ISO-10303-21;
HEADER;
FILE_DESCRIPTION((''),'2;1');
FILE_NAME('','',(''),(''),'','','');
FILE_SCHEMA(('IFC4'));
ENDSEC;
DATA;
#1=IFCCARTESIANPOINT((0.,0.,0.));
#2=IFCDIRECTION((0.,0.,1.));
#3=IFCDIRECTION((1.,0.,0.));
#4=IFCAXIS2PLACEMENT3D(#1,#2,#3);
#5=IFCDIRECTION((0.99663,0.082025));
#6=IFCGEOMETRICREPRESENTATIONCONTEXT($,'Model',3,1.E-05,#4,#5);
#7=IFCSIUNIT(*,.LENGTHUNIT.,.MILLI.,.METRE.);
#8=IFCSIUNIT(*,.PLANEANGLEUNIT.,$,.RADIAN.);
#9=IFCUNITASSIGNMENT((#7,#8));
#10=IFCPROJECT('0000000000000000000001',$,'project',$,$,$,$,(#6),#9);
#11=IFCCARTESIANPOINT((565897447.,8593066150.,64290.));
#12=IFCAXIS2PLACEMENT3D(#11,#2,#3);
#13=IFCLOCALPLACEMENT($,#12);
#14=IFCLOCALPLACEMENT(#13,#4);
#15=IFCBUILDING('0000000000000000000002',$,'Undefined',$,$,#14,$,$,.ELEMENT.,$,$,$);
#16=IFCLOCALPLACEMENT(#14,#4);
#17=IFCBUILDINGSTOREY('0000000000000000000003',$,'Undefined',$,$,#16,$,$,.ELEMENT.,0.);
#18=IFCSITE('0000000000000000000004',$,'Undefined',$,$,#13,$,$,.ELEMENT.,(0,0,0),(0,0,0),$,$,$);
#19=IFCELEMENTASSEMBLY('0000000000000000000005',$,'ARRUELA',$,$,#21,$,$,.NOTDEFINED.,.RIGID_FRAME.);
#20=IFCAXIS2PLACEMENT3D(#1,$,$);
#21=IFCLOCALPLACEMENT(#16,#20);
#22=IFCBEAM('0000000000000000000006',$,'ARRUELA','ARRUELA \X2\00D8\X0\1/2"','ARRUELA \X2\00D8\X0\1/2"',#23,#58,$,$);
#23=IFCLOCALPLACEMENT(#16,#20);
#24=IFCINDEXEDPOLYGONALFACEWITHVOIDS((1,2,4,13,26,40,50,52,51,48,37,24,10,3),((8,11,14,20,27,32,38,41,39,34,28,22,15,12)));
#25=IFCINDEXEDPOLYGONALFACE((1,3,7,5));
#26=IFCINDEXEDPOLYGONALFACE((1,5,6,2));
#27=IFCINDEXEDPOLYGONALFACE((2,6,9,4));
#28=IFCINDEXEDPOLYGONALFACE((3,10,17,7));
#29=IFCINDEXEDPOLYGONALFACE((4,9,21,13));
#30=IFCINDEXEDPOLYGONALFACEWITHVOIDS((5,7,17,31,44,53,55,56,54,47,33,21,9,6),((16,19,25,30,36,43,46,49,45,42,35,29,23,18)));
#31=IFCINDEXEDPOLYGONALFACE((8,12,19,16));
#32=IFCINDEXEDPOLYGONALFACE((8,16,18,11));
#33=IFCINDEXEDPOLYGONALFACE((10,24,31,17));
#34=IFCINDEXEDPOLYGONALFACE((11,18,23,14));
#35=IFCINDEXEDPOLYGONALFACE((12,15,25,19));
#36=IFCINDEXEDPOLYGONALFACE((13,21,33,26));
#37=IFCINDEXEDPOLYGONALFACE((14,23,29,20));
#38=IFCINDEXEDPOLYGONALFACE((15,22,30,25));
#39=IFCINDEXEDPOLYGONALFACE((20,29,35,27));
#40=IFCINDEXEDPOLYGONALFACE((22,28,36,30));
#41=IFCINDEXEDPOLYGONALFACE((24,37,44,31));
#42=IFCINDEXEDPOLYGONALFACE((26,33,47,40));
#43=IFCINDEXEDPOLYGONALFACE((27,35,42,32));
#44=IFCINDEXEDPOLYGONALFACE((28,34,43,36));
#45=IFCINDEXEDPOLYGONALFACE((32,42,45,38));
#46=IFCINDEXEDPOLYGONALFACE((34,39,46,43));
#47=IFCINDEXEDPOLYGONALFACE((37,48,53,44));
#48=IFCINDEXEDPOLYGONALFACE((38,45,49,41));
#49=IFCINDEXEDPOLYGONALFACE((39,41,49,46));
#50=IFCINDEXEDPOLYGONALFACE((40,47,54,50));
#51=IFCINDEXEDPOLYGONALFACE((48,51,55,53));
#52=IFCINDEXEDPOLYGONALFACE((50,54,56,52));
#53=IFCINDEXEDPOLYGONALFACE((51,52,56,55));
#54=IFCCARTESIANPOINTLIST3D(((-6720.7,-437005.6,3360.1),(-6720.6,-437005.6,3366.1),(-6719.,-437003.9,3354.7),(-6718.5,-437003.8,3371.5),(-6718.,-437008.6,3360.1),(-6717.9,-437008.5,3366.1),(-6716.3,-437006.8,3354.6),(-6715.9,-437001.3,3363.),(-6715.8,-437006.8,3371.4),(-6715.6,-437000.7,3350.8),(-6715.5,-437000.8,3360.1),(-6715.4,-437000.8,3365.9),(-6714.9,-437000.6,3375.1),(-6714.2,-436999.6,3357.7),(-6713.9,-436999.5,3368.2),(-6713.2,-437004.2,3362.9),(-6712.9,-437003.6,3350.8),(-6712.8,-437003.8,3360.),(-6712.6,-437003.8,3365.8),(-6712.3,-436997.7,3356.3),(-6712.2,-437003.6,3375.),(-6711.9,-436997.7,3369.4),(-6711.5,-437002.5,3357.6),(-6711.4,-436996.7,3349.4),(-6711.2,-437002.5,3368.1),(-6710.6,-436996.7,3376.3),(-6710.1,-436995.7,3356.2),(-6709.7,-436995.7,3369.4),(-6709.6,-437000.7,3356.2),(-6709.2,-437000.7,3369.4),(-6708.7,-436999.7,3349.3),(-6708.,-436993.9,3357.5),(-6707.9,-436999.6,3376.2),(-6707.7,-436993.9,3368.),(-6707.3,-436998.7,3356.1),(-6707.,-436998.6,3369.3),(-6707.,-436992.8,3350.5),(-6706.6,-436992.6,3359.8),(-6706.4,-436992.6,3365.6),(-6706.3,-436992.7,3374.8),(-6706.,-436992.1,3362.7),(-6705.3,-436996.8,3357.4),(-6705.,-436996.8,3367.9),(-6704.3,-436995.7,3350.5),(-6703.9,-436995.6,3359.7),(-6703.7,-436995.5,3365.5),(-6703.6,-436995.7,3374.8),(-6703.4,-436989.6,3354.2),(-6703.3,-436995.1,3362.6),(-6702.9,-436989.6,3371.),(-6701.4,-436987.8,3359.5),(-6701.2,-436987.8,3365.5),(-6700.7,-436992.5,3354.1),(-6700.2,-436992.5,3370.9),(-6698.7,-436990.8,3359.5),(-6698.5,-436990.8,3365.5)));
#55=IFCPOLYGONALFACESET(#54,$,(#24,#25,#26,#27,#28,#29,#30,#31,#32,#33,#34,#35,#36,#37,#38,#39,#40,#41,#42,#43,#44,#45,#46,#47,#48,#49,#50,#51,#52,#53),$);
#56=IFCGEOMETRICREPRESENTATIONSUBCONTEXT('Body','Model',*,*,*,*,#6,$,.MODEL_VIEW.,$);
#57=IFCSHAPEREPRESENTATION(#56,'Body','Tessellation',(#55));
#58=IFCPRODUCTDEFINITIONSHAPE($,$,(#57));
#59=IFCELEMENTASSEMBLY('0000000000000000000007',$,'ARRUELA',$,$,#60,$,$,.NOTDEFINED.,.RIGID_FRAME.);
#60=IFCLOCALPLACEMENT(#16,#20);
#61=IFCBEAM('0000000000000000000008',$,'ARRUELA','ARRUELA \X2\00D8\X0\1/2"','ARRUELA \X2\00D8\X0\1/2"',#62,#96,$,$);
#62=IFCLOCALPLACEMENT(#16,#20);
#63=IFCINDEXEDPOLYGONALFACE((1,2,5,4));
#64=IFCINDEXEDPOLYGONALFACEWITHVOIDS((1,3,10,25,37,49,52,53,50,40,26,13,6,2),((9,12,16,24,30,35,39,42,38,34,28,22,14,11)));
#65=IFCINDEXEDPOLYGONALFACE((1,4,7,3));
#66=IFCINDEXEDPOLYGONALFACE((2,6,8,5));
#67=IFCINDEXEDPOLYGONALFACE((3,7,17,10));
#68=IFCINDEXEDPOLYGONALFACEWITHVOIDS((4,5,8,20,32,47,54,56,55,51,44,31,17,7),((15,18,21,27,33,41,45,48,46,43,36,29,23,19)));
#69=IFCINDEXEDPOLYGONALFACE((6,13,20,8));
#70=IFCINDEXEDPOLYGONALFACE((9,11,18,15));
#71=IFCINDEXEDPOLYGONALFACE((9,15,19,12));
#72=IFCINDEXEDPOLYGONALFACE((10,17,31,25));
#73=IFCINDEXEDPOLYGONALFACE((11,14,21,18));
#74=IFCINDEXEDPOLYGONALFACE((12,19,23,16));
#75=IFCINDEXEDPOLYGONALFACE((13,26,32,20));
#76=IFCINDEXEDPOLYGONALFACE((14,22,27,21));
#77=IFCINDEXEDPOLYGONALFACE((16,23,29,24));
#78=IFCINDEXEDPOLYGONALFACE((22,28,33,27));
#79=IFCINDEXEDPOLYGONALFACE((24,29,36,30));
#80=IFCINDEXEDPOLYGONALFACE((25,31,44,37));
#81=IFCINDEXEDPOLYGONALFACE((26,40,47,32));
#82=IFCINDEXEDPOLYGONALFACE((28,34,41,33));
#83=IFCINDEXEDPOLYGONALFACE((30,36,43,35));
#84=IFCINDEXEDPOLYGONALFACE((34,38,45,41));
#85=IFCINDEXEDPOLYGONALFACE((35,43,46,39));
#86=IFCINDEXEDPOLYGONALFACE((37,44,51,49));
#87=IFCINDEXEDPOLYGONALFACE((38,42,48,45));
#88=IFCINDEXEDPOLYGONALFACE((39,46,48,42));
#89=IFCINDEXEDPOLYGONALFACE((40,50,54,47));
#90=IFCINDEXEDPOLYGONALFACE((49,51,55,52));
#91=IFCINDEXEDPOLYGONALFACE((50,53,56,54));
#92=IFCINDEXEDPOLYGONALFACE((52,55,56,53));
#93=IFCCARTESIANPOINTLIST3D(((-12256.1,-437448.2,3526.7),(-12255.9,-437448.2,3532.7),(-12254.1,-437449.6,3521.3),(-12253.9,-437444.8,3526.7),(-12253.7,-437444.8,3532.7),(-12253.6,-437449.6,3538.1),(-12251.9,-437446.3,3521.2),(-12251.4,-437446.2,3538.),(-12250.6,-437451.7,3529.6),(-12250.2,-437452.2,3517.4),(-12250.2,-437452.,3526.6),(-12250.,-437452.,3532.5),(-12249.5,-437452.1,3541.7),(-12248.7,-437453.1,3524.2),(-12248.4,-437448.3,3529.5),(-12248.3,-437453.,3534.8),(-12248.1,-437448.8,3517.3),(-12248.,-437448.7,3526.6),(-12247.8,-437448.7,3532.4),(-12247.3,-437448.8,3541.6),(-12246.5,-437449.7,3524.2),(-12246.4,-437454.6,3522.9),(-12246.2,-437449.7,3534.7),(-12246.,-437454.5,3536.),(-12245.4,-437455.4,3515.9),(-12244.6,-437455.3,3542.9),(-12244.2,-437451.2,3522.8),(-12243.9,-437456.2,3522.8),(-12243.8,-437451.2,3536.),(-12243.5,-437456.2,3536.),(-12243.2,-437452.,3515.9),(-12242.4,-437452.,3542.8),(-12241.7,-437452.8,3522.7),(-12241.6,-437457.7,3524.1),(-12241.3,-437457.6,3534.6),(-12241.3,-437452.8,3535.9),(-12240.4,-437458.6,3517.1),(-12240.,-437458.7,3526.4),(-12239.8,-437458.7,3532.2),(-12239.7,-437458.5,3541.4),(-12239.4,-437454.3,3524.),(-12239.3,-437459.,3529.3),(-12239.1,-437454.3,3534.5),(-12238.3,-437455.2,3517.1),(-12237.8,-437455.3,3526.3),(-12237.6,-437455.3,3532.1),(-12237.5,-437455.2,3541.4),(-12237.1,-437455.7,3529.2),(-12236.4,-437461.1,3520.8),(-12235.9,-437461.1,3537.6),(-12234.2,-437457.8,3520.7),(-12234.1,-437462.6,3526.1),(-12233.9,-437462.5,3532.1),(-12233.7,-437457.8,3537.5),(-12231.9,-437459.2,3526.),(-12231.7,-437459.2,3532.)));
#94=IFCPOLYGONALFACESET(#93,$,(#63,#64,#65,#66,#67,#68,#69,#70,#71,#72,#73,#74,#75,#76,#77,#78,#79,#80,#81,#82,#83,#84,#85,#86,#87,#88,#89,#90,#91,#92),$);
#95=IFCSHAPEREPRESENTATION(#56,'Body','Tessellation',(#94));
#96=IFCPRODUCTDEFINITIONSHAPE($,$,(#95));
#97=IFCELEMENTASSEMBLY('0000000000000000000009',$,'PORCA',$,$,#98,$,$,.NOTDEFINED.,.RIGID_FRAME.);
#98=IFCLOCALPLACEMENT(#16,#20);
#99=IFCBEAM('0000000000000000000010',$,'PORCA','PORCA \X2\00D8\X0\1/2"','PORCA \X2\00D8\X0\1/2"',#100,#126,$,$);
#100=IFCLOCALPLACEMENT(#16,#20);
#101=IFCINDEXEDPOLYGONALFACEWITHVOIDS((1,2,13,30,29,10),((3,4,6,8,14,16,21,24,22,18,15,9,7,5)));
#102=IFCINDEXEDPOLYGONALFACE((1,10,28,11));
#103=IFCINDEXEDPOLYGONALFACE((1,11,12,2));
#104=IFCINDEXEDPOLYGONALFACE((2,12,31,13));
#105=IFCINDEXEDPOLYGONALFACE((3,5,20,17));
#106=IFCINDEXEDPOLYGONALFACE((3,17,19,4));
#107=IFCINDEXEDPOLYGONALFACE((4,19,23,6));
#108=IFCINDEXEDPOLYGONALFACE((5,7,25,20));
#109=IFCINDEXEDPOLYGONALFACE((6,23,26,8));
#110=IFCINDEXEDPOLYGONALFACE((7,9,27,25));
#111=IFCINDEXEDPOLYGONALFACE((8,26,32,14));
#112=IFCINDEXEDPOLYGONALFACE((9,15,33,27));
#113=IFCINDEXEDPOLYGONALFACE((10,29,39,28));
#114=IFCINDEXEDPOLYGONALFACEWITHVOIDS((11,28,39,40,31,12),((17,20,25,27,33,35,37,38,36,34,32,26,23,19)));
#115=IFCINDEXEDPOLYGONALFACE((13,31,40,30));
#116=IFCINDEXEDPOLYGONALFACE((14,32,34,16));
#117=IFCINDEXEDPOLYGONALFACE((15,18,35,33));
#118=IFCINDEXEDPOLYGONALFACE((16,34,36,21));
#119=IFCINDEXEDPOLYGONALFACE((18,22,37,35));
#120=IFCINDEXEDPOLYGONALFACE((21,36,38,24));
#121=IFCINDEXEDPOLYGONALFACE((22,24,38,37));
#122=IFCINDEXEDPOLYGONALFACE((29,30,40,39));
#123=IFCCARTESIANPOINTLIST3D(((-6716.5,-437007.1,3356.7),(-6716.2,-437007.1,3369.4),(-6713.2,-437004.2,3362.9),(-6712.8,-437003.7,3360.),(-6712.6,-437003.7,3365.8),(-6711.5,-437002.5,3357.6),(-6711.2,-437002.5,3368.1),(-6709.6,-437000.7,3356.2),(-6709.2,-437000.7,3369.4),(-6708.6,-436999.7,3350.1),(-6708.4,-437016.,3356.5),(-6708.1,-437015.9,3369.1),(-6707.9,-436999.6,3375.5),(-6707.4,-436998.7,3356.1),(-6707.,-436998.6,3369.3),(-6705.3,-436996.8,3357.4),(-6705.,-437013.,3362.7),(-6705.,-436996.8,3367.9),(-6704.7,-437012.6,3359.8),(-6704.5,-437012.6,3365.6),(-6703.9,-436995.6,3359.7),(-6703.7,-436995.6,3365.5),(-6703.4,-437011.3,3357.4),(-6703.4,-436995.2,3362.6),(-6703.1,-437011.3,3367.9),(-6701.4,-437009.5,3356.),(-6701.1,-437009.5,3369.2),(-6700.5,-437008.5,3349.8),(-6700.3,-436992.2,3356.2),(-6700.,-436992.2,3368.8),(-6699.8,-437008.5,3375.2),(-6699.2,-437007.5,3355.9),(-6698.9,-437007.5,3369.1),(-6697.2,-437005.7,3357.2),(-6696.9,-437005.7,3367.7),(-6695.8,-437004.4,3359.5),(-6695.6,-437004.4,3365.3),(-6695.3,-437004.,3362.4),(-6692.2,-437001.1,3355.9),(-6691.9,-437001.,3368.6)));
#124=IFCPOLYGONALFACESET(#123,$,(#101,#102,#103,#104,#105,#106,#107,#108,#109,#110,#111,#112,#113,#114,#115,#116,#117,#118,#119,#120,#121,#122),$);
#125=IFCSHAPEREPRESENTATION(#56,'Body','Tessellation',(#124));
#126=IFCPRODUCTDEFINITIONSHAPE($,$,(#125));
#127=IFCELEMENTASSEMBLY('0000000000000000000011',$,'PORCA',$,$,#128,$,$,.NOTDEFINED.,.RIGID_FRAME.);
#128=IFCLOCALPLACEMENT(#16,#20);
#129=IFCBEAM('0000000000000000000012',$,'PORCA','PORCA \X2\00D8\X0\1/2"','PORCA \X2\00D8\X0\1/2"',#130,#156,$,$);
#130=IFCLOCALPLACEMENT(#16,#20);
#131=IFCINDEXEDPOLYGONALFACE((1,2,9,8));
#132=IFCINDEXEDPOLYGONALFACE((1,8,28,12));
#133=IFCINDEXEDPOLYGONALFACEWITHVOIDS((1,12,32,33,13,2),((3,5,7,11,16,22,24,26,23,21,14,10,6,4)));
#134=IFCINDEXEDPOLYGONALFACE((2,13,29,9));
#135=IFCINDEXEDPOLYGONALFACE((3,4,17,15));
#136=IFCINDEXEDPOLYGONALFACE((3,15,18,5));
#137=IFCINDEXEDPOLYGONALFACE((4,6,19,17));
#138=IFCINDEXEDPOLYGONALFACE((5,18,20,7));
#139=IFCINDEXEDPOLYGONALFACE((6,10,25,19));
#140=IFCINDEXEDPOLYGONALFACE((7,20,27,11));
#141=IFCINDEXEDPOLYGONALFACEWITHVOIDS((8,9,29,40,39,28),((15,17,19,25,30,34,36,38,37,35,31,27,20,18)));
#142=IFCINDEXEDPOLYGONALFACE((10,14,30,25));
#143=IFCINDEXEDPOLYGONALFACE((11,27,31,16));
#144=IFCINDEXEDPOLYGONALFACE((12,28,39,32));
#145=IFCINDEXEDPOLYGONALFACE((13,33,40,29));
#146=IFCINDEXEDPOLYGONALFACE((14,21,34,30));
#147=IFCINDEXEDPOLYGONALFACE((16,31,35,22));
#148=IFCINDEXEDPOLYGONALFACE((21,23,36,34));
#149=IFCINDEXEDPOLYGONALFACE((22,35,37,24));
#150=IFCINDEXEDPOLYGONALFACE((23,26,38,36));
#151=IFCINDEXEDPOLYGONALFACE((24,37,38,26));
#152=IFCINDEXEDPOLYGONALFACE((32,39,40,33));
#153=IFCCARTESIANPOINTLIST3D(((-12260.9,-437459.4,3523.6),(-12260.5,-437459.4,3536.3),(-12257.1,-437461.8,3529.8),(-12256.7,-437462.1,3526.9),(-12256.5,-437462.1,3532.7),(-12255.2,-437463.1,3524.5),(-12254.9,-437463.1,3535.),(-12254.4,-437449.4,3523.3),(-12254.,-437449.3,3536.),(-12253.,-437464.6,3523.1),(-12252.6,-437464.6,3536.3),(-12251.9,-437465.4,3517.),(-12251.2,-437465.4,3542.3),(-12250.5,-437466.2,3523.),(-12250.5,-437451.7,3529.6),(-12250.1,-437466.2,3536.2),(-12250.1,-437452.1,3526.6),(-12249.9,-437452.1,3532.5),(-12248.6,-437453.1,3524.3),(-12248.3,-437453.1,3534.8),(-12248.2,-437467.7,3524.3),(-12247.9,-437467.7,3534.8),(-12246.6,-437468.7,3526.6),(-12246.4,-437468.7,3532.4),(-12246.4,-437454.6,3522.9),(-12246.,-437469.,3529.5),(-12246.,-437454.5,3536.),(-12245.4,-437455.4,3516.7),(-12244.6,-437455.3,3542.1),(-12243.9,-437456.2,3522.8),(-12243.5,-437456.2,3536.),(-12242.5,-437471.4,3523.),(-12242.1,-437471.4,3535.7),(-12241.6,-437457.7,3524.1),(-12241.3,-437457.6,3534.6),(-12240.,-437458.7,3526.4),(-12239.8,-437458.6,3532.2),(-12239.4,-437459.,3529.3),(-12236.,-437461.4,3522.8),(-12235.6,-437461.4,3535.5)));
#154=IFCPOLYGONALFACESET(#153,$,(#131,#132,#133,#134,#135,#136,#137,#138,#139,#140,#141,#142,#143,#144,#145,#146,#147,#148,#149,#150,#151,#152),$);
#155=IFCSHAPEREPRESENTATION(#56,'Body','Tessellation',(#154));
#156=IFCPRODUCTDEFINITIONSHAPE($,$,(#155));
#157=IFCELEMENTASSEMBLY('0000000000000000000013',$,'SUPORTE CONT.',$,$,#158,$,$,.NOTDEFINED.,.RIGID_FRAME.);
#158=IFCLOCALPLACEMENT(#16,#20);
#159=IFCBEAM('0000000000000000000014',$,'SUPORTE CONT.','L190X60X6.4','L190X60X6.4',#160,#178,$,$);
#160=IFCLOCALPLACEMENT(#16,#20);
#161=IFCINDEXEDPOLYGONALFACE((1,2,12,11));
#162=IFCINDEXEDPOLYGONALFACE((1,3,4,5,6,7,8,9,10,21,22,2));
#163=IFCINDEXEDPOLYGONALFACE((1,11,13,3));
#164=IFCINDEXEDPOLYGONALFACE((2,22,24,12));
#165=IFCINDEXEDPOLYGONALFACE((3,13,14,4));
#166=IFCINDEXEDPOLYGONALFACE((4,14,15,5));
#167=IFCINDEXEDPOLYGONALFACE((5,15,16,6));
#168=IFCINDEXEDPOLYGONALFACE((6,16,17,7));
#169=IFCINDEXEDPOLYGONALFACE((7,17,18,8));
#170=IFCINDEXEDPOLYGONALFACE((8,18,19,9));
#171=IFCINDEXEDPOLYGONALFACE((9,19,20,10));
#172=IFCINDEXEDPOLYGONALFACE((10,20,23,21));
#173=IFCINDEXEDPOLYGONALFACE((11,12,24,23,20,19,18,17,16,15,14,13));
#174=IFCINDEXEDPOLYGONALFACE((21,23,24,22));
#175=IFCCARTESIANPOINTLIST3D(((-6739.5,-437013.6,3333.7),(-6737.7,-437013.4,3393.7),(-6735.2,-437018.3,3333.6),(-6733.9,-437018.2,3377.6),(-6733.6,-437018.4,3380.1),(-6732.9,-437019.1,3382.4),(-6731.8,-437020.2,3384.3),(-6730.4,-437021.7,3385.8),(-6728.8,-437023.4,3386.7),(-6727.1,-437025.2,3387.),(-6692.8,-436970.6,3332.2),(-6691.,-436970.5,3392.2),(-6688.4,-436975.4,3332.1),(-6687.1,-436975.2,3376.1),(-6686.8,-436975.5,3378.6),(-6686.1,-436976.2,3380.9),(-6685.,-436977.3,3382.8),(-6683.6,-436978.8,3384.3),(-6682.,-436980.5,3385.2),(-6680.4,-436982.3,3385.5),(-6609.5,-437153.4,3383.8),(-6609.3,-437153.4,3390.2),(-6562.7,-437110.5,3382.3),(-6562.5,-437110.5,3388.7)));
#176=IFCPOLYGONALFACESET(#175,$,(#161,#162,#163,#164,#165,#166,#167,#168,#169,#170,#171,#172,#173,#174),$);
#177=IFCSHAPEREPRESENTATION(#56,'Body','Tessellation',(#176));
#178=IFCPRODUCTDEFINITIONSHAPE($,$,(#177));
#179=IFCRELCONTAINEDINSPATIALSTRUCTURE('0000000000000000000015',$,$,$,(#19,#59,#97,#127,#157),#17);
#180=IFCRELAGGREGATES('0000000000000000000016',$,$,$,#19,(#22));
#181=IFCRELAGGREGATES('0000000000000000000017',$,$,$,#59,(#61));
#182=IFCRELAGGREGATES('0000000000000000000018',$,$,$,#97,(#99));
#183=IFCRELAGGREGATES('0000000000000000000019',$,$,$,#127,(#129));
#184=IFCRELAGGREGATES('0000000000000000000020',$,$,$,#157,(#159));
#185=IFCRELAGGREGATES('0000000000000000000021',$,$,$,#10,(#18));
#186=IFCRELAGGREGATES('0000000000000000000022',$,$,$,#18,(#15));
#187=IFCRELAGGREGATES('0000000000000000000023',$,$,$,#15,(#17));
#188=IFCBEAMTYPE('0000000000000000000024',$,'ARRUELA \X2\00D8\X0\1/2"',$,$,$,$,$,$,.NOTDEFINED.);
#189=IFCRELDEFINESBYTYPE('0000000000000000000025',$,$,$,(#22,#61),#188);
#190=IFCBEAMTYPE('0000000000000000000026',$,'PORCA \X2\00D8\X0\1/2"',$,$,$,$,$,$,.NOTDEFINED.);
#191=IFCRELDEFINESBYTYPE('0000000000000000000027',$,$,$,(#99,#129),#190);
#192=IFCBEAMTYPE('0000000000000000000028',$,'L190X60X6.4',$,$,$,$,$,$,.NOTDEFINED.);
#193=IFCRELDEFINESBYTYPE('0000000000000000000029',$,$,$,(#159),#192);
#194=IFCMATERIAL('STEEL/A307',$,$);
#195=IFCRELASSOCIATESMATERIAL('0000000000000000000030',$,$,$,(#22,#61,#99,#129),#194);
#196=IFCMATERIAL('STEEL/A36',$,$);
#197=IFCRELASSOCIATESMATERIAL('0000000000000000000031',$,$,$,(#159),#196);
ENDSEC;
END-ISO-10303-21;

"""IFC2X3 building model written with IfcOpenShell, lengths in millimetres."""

from ifc_helpers import new_model, si_unit, direction, frame, origin_with_axes, origin_2d_with_axis, place, context, subcontext, project, spatial, polyline, l_section, outline, extrude, material, type_object, element, aggregate, save


model = new_model("IFC2X3")

# Units and contexts
model_context = context("Model", 3, precision=1e-05, world=origin_with_axes(), true_north=direction((0.99663, 0.082025)))
body_context = subcontext(model_context, "Body", "Model", "MODEL_VIEW")
ifc_project = project(units=[si_unit("LENGTHUNIT", "METRE", prefix="MILLI"), si_unit("PLANEANGLEUNIT", "RADIAN")], contexts=[model_context])

# Site, building, storey
site_placement = place(None, frame((565897447.0, 8593066150.0, 64290.0), z_axis=(0.0, 0.0, 1.0), x_axis=(1.0, 0.0, 0.0)))
site = spatial("IfcSite", under=ifc_project, at=site_placement, Name="Undefined", CompositionType="ELEMENT", RefLatitude=(0, 0, 0), RefLongitude=(0, 0, 0))
building_placement = place(site_placement, origin_with_axes())
building = spatial("IfcBuilding", under=site, at=building_placement, Name="Undefined", CompositionType="ELEMENT")
storey_placement = place(building_placement, origin_with_axes())
storey = spatial("IfcBuildingStorey", under=building, at=storey_placement, Name="Undefined", CompositionType="ELEMENT", Elevation=0.0)

# Element assemblies, beams
assembly_1_placement = place(storey_placement, origin_with_axes())
assembly_1 = element("IfcElementAssembly", 1, at=assembly_1_placement, inside=storey, Name="ARRUELA", AssemblyPlace="NOTDEFINED", PredefinedType="RIGID_FRAME")
ifc_material_1 = material(Name="STEEL/A307")
beam_type_1 = type_object("IfcBeamType", Name="ARRUELA Ø1/2\"", PredefinedType="NOTDEFINED")
beam_1_placement = place(assembly_1_placement, frame((-6708.3, -436999.7, 3362.8), z_axis=(-0.736334, -0.676203, 0.02368), x_axis=(-0.675958, 0.736711, 0.018398)))
beam_1 = element("IfcBeam", 2, at=beam_1_placement, type_object=beam_type_1, material=ifc_material_1, Name="ARRUELA", Description="ARRUELA Ø1/2\"", ObjectType="ARRUELA Ø1/2\"", context=body_context, shape_type="SweptSolid", body=[
    extrude(outline(polyline([(-12.2, 5.9), (-8.4, 10.5), (-3.0, 13.2), (3.0, 13.2), (8.4, 10.5), (12.2, 5.9), (13.5, 0.0), (12.2, -5.9), (8.4, -10.5), (3.0, -13.2), (-3.0, -13.2), (-8.4, -10.5), (-12.2, -5.9), (-13.5, 0.0), (-12.2, 5.9)]), holes=[polyline([(5.3, 4.2), (2.9, 6.1), (0.0, 6.8), (-2.9, 6.1), (-5.3, 4.2), (-6.6, 1.5), (-6.6, -1.5), (-5.3, -4.2), (-2.9, -6.1), (0.0, -6.7), (2.9, -6.1), (5.3, -4.2), (6.6, -1.5), (6.6, 1.5), (5.3, 4.2)])]), frame((4.0, 0.0, 0.0), z_axis=(-1.0, 0.0, 0.0), x_axis=(0.0, -1.0, 0.0)), (0.0, 0.0, 1.0), 4.0),
])
aggregate(assembly_1, [beam_1])
assembly_2_placement = place(storey_placement, origin_with_axes())
assembly_2 = element("IfcElementAssembly", 3, at=assembly_2_placement, inside=storey, Name="ARRUELA", AssemblyPlace="NOTDEFINED", PredefinedType="RIGID_FRAME")
beam_2_placement = place(assembly_2_placement, frame((-12245.0, -437455.4, 3529.4), z_axis=(-0.836984, 0.546715, 0.02368), x_axis=(0.546411, 0.837315, -0.018398)))
beam_2 = element("IfcBeam", 4, at=beam_2_placement, type_object=beam_type_1, material=ifc_material_1, Name="ARRUELA", Description="ARRUELA Ø1/2\"", ObjectType="ARRUELA Ø1/2\"", context=body_context, shape_type="SweptSolid", body=[
    extrude(outline(polyline([(-12.2, 5.9), (-8.4, 10.5), (-3.0, 13.2), (3.0, 13.2), (8.4, 10.5), (12.2, 5.9), (13.5, 0.0), (12.2, -5.9), (8.4, -10.5), (3.0, -13.2), (-3.0, -13.2), (-8.4, -10.5), (-12.2, -5.9), (-13.5, 0.0), (-12.2, 5.9)]), holes=[polyline([(5.3, 4.2), (2.9, 6.1), (0.0, 6.8), (-2.9, 6.1), (-5.3, 4.2), (-6.6, 1.5), (-6.6, -1.5), (-5.3, -4.2), (-2.9, -6.1), (0.0, -6.7), (2.9, -6.1), (5.3, -4.2), (6.6, -1.5), (6.6, 1.5), (5.3, 4.2)])]), frame((4.0, 0.0, 0.0), z_axis=(-1.0, 0.0, 0.0), x_axis=(0.0, -1.0, 0.0)), (0.0, 0.0, 1.0), 4.0),
])
aggregate(assembly_2, [beam_2])
assembly_3_placement = place(storey_placement, origin_with_axes())
assembly_3 = element("IfcElementAssembly", 5, at=assembly_3_placement, inside=storey, Name="PORCA", AssemblyPlace="NOTDEFINED", PredefinedType="RIGID_FRAME")
beam_type_2 = type_object("IfcBeamType", Name="PORCA Ø1/2\"", PredefinedType="NOTDEFINED")
beam_3_placement = place(assembly_3_placement, frame((-6700.1, -437008.5, 3362.5), z_axis=(-0.736334, -0.676203, 0.02368), x_axis=(-0.675958, 0.736711, 0.018398)))
beam_3 = element("IfcBeam", 6, at=beam_3_placement, type_object=beam_type_2, material=ifc_material_1, Name="PORCA", Description="PORCA Ø1/2\"", ObjectType="PORCA Ø1/2\"", context=body_context, shape_type="SweptSolid", body=[
    extrude(outline(polyline([(-6.3, -11.0), (-12.7, 0.0), (-6.3, 11.0), (6.3, 11.0), (12.7, 0.0), (6.3, -11.0), (-6.3, -11.0)]), holes=[polyline([(5.3, 4.2), (2.9, 6.0), (0.0, 6.7), (-2.9, 6.0), (-5.3, 4.2), (-6.6, 1.5), (-6.6, -1.5), (-5.3, -4.2), (-2.9, -6.0), (0.0, -6.7), (2.9, -6.0), (5.3, -4.2), (6.6, -1.5), (6.6, 1.5), (5.3, 4.2)])]), frame((12.0, 0.0, 0.0), z_axis=(-1.0, 0.0, 0.0), x_axis=(0.0, -1.0, 0.0)), (0.0, 0.0, 1.0), 12.0),
])
aggregate(assembly_3, [beam_3])
assembly_4_placement = place(storey_placement, origin_with_axes())
assembly_4 = element("IfcElementAssembly", 7, at=assembly_4_placement, inside=storey, Name="PORCA", AssemblyPlace="NOTDEFINED", PredefinedType="RIGID_FRAME")
beam_4_placement = place(assembly_4_placement, frame((-12251.5, -437465.4, 3529.6), z_axis=(-0.836984, 0.546715, 0.02368), x_axis=(0.546411, 0.837315, -0.018398)))
beam_4 = element("IfcBeam", 8, at=beam_4_placement, type_object=beam_type_2, material=ifc_material_1, Name="PORCA", Description="PORCA Ø1/2\"", ObjectType="PORCA Ø1/2\"", context=body_context, shape_type="SweptSolid", body=[
    extrude(outline(polyline([(-6.3, -11.0), (-12.7, 0.0), (-6.3, 11.0), (6.3, 11.0), (12.7, 0.0), (6.3, -11.0), (-6.3, -11.0)]), holes=[polyline([(5.3, 4.2), (2.9, 6.0), (0.0, 6.7), (-2.9, 6.0), (-5.3, 4.2), (-6.6, 1.5), (-6.6, -1.5), (-5.3, -4.2), (-2.9, -6.0), (0.0, -6.7), (2.9, -6.0), (5.3, -4.2), (6.6, -1.5), (6.6, 1.5), (5.3, 4.2)])]), frame((12.0, 0.0, 0.0), z_axis=(-1.0, 0.0, 0.0), x_axis=(0.0, -1.0, 0.0)), (0.0, 0.0, 1.0), 12.0),
])
aggregate(assembly_4, [beam_4])
assembly_5_placement = place(storey_placement, origin_with_axes())
assembly_5 = element("IfcElementAssembly", 9, at=assembly_5_placement, inside=storey, Name="SUPORTE CONT.", AssemblyPlace="NOTDEFINED", PredefinedType="RIGID_FRAME")
ifc_material_2 = material(Name="STEEL/A36")
beam_type_3 = type_object("IfcBeamType", Name="L190X60X6.4", PredefinedType="NOTDEFINED")
beam_5_placement = place(assembly_5_placement, frame((-6674.4, -437083.5, 3362.0), z_axis=(0.675958, -0.736711, -0.018398), x_axis=(0.736334, 0.676203, -0.02368)))
beam_5 = element("IfcBeam", 10, at=beam_5_placement, type_object=beam_type_3, material=ifc_material_2, Name="SUPORTE CONT.", Description="L190X60X6.4", ObjectType="L190X60X6.4", context=body_context, shape_type="SweptSolid", body=[
    extrude(l_section(Depth=190.0, Width=60.0, Thickness=6.4, FilletRadius=9.6, at=origin_2d_with_axis()), frame((63.5, 0.0, 0.0), z_axis=(-1.0, 0.0, 0.0), x_axis=(0.0, -1.0, 0.0)), (0.0, 0.0, 1.0), 63.5),
])

aggregate(assembly_5, [beam_5])

save(model, "model.ifc")
